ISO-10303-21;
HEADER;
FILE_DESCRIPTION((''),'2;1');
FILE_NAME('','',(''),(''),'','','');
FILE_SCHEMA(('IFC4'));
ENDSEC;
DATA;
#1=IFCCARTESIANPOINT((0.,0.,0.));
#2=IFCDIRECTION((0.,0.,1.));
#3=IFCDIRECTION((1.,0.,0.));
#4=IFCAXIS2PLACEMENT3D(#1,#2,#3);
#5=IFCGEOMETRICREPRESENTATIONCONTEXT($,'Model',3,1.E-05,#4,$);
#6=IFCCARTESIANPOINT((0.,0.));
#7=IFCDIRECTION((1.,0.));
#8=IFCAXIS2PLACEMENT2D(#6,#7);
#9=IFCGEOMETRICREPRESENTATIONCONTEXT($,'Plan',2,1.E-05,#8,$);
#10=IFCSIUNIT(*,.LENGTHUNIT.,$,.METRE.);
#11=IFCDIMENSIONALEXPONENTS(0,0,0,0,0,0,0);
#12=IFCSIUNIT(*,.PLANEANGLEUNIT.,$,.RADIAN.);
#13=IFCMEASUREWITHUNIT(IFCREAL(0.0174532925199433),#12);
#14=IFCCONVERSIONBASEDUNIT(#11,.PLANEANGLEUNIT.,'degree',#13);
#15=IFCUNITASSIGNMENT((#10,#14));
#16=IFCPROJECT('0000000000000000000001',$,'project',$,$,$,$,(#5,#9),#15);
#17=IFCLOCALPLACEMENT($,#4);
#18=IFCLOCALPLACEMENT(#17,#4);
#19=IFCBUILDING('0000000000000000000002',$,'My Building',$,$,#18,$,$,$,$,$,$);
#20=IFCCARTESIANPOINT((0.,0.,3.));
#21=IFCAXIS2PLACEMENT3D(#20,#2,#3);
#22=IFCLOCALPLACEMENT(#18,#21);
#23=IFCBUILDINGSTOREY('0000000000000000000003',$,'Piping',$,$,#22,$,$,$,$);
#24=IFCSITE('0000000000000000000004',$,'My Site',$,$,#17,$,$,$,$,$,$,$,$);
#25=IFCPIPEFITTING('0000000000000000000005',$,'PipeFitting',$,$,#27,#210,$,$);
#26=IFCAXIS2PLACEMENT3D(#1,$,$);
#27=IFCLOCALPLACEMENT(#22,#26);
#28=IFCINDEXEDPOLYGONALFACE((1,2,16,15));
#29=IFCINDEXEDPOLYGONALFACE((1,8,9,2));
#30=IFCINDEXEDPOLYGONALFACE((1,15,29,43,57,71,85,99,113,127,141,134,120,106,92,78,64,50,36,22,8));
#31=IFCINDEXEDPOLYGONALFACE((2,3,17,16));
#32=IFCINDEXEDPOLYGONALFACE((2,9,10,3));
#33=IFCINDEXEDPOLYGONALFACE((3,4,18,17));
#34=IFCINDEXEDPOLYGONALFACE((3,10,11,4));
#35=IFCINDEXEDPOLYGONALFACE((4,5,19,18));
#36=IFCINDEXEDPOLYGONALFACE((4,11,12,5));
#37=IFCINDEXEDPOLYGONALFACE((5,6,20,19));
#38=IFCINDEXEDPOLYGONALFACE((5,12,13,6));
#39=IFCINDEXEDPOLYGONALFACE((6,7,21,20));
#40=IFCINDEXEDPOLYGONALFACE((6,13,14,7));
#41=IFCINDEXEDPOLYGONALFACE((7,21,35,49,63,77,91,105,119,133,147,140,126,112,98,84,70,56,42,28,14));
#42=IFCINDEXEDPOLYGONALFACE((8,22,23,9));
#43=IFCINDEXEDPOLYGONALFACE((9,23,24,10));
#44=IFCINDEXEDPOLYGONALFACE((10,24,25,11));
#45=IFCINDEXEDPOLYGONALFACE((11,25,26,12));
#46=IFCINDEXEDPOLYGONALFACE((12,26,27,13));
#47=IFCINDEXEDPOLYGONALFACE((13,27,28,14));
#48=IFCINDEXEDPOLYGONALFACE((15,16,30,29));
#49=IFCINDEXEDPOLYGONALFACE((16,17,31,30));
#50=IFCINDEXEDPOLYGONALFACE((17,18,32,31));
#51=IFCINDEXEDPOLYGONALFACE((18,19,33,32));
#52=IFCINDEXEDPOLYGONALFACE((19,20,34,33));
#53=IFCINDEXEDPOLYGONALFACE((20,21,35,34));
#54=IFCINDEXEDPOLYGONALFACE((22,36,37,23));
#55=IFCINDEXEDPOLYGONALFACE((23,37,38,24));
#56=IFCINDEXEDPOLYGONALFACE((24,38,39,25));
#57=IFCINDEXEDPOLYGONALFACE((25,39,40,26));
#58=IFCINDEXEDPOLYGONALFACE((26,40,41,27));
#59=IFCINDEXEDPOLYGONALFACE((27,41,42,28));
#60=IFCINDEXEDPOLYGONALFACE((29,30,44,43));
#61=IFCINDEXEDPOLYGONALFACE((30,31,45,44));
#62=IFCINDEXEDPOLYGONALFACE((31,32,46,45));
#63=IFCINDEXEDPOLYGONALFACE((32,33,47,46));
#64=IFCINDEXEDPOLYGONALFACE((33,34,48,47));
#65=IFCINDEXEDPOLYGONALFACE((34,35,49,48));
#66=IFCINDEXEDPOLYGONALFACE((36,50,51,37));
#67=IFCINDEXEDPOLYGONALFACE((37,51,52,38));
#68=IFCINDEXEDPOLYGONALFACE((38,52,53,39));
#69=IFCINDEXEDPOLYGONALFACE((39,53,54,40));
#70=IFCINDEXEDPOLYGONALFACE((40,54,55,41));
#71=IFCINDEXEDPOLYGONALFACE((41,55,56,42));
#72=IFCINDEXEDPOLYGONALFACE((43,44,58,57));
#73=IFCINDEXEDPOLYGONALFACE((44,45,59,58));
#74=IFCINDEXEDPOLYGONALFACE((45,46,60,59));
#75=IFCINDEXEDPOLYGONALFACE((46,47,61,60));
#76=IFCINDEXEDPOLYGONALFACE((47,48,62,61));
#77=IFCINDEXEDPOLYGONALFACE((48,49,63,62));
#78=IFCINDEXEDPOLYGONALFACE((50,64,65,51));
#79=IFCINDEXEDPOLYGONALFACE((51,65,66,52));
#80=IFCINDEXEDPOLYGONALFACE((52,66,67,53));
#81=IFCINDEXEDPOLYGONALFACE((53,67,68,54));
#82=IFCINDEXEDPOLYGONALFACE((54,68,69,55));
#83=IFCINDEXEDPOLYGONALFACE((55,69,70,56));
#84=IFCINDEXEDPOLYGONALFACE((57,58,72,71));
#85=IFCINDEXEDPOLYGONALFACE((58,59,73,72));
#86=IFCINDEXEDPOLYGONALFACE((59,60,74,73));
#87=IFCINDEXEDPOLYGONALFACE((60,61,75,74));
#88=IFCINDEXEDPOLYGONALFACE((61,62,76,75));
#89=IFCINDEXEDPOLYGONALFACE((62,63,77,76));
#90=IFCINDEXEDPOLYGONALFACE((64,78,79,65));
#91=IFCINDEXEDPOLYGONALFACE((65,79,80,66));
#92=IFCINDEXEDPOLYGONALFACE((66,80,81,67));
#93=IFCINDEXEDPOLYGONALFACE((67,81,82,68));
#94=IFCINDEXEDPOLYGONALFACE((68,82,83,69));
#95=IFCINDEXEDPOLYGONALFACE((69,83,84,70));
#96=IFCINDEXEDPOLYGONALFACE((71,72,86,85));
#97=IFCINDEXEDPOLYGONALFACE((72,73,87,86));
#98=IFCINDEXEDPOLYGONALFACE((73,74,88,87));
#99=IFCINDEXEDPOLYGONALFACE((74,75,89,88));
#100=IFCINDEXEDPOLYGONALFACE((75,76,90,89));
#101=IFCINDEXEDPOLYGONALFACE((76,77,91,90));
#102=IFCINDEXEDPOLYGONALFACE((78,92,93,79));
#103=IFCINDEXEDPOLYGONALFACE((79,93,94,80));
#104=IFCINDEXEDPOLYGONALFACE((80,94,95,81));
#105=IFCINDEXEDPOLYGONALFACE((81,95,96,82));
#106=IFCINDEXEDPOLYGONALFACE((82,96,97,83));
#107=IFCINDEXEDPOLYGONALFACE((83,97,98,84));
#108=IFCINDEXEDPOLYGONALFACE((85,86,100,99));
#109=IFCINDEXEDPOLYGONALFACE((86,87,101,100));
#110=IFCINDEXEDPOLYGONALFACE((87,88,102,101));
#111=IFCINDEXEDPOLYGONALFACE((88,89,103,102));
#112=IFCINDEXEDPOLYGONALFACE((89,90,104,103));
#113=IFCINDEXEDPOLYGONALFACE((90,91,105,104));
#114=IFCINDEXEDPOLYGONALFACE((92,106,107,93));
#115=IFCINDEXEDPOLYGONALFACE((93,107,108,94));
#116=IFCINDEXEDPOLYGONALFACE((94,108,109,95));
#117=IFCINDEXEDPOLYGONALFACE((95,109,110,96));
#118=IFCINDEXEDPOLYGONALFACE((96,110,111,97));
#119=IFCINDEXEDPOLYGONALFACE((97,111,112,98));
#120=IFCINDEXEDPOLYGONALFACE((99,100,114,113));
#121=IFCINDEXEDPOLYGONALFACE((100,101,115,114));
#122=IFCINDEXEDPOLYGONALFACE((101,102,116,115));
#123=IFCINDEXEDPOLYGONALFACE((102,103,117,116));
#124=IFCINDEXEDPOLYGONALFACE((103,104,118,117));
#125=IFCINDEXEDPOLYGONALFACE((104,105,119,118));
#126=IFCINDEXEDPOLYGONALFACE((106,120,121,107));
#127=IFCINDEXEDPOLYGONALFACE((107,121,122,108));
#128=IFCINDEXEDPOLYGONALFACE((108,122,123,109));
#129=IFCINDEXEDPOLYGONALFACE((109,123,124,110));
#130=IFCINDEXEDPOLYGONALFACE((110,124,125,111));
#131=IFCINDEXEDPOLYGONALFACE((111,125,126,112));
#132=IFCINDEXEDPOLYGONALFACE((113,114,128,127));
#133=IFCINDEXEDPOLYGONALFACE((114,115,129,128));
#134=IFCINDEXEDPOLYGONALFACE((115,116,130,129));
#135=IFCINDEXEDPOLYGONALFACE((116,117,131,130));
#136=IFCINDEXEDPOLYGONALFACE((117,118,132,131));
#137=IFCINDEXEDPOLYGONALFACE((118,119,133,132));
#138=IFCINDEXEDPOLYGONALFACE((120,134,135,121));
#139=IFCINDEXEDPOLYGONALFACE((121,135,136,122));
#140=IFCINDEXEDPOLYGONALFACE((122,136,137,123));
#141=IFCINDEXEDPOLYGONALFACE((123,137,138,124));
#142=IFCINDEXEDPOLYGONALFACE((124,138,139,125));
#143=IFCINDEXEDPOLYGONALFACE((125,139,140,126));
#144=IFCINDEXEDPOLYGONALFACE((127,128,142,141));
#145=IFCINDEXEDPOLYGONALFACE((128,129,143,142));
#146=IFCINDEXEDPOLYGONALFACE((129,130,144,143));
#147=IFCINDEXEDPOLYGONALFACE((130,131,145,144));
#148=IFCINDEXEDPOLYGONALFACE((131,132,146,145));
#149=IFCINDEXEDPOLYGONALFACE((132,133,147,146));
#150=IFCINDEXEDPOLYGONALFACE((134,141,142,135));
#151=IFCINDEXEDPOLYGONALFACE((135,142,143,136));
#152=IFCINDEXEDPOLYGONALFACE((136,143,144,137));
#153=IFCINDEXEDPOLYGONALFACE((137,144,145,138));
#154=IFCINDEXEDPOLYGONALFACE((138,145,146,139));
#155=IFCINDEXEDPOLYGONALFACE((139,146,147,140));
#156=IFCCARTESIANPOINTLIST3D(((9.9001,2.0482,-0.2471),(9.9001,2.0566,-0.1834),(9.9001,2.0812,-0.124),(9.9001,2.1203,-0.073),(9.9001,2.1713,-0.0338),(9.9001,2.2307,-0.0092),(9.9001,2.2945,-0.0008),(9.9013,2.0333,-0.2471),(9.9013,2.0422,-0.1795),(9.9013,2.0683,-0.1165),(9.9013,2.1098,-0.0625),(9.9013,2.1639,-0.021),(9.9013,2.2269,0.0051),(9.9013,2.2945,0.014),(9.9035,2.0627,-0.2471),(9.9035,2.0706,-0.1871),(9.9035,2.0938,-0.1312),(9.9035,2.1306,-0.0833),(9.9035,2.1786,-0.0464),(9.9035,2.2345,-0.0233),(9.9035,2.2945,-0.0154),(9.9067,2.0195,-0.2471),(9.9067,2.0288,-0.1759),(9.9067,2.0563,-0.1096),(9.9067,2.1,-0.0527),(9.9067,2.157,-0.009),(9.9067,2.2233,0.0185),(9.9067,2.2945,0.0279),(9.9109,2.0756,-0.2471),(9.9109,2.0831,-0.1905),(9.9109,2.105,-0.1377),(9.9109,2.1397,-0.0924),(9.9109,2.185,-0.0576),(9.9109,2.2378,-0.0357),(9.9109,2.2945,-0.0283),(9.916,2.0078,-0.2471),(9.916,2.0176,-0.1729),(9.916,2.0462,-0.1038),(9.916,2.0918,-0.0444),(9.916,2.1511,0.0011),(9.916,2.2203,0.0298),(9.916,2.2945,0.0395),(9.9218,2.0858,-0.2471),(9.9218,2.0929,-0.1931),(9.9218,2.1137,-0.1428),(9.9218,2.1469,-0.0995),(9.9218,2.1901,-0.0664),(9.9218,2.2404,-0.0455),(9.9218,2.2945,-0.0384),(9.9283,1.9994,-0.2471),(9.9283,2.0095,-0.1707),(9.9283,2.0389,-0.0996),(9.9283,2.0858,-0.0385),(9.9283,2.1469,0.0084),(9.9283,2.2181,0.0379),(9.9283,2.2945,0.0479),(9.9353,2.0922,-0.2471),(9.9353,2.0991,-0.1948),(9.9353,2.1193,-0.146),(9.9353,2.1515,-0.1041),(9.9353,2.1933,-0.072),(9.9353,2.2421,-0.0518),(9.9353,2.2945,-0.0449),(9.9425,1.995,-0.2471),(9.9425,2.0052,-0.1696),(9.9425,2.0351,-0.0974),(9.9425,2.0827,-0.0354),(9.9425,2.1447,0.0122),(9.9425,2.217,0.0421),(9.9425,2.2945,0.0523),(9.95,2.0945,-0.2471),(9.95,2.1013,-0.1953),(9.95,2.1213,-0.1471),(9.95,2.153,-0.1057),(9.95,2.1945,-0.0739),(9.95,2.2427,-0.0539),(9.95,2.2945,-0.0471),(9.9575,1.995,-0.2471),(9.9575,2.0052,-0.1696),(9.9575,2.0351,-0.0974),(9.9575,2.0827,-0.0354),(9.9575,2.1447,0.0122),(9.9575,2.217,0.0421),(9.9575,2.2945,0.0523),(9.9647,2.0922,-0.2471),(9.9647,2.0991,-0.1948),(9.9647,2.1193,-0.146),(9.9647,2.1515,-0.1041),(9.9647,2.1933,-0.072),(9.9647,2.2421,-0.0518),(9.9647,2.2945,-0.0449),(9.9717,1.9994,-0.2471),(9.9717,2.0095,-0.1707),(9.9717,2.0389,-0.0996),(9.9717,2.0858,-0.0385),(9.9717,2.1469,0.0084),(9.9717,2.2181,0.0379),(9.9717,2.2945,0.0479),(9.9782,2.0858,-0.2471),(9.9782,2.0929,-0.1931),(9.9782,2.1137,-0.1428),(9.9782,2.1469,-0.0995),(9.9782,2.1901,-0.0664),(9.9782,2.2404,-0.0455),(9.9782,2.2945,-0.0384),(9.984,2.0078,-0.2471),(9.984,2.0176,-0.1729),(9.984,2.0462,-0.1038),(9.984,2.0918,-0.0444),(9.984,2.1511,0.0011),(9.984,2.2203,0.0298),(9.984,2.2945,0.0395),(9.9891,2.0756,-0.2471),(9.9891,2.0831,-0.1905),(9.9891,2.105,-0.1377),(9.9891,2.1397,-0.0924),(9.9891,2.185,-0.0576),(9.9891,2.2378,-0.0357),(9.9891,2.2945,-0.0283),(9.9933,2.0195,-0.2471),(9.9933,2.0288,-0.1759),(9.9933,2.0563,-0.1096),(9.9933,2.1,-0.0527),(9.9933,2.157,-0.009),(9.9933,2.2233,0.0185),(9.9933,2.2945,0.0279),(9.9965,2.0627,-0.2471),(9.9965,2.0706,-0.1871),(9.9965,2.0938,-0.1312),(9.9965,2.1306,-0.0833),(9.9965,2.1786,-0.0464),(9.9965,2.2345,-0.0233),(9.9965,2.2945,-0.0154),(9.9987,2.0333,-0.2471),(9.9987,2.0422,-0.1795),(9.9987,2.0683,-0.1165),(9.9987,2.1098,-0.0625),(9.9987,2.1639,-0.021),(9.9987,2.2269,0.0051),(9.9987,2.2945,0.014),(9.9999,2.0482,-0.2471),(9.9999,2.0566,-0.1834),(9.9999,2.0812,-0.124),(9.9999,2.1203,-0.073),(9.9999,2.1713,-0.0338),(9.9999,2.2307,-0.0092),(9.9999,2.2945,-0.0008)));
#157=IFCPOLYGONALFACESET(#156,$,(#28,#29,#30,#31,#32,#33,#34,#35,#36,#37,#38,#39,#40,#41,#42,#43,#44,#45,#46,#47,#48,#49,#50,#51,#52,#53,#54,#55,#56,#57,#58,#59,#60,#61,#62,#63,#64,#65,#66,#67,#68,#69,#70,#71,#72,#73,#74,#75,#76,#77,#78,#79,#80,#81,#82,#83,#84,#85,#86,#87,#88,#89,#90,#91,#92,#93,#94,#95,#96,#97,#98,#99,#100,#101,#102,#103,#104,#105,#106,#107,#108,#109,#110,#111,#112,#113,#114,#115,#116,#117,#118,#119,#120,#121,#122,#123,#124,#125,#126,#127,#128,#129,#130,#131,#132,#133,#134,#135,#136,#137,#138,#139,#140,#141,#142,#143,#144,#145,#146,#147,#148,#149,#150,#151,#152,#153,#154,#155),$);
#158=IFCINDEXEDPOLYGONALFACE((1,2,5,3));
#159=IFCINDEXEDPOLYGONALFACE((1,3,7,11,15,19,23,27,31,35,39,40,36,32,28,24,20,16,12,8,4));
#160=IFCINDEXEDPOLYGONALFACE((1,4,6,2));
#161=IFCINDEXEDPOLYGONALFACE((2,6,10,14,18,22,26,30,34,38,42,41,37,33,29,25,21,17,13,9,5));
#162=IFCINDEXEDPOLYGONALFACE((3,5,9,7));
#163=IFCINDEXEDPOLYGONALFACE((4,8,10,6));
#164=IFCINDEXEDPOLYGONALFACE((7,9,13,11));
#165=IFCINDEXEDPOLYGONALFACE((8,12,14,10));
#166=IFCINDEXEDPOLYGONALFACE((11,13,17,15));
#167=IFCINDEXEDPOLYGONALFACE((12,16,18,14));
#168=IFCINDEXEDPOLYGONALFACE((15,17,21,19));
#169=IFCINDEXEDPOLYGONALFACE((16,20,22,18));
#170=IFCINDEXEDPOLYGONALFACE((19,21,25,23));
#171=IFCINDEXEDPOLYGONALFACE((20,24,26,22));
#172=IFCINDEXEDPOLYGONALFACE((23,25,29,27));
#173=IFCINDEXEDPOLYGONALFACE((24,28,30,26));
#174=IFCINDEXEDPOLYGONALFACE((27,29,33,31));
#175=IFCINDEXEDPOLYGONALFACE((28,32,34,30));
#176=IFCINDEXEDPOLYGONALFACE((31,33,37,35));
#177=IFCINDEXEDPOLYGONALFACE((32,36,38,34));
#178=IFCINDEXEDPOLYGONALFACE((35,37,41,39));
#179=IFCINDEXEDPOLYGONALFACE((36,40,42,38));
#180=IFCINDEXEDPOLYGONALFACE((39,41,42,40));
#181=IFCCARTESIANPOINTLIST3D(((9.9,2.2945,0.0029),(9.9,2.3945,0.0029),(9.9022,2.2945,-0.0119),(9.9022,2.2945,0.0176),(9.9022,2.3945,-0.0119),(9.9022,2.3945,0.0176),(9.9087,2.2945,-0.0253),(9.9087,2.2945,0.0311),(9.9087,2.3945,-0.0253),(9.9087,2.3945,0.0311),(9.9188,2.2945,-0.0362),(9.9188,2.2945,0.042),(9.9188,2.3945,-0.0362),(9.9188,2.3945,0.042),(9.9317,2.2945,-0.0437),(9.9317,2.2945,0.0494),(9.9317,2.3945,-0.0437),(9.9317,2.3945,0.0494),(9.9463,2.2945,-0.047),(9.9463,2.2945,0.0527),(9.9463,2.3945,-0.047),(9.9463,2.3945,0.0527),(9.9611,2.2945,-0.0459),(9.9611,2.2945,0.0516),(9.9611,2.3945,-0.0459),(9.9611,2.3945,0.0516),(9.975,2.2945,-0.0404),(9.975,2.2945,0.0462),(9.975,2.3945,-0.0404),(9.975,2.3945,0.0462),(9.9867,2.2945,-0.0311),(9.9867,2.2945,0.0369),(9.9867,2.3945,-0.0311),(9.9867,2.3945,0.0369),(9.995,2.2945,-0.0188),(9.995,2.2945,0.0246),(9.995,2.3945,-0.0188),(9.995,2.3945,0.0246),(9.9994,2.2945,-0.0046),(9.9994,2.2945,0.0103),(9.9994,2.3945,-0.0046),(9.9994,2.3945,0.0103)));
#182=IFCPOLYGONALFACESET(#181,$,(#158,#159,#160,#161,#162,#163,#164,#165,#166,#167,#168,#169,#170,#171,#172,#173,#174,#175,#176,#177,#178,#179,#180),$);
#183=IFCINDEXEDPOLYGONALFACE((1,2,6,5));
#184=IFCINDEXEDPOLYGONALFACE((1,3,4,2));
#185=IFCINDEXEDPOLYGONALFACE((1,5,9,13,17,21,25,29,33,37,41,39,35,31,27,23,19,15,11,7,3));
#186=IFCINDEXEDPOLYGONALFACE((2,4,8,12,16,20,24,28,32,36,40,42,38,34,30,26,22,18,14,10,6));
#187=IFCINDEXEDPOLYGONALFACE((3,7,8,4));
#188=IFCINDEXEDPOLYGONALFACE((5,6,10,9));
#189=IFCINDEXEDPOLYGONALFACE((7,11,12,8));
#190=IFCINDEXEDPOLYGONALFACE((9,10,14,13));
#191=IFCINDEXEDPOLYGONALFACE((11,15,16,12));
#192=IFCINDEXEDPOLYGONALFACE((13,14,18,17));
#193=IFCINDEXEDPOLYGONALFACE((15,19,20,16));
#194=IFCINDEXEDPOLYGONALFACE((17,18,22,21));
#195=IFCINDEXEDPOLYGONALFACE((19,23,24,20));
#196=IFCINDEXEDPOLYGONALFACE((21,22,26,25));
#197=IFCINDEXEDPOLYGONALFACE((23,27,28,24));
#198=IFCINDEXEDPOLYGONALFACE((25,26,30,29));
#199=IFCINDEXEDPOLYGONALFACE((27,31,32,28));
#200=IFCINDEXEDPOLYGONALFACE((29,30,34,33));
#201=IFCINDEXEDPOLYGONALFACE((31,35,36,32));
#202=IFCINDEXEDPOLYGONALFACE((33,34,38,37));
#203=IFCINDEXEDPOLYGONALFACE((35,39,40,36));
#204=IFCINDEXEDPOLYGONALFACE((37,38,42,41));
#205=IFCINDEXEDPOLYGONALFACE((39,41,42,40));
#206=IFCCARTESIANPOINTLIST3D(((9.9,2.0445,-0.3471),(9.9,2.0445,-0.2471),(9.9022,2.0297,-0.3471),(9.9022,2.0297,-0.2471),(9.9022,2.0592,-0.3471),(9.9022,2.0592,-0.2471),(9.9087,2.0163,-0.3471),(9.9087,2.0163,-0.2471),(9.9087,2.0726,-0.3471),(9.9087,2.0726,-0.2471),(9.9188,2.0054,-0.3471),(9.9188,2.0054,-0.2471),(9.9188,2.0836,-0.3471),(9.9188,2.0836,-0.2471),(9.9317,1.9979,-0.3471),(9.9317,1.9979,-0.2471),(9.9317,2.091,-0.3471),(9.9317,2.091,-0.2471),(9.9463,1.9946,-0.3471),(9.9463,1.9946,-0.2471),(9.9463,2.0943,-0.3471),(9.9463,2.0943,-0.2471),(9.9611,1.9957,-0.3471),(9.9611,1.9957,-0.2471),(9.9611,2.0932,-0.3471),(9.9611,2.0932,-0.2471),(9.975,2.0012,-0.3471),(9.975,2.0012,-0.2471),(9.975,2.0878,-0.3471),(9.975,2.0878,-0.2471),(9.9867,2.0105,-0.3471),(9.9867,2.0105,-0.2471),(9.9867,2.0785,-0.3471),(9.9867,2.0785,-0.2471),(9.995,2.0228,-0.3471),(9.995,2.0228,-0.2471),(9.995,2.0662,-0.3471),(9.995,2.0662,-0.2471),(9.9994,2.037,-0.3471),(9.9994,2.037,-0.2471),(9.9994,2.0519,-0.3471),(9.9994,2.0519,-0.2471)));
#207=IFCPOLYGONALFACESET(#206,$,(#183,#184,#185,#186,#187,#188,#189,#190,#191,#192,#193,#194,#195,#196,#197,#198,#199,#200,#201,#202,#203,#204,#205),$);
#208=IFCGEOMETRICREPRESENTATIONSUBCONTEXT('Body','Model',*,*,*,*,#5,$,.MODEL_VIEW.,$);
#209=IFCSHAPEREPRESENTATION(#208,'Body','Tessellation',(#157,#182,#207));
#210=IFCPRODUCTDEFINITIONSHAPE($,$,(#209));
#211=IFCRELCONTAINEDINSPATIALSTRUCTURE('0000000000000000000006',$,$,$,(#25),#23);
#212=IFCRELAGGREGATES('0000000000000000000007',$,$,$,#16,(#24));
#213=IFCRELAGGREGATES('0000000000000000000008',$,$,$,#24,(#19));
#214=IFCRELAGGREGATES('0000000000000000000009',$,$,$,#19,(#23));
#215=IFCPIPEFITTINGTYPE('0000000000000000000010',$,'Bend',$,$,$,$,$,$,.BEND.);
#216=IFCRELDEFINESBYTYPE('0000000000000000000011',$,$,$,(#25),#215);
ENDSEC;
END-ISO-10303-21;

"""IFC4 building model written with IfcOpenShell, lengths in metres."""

from ifc_helpers import new_model, entity, si_unit, converted_unit, frame, origin_with_axes, origin_2d_with_axis, place, context, subcontext, project, spatial, circle, extrude, source, transform, mapped, type_object, type_shapes, element, save


model = new_model("IFC4")

# Units and contexts
model_context = context("Model", 3, precision=1e-05, world=origin_with_axes())
plan_context = context("Plan", 2, precision=1e-05, world=origin_2d_with_axis())
body_context = subcontext(model_context, "Body", "Model", "MODEL_VIEW")
ifc_project = project(units=[si_unit("LENGTHUNIT", "METRE"), converted_unit("PLANEANGLEUNIT", "degree", entity("IfcReal", 0.0174532925199433), si_unit("PLANEANGLEUNIT", "RADIAN"), dimensions=[0, 0, 0, 0, 0, 0, 0])], contexts=[model_context, plan_context])

# Site, building, storey
site_placement = place(None, origin_with_axes())
site = spatial("IfcSite", under=ifc_project, at=site_placement, Name="My Site")
building_placement = place(site_placement, origin_with_axes())
building = spatial("IfcBuilding", under=site, at=building_placement, Name="My Building")
storey_placement = place(building_placement, frame((0.0, 0.0, 3.0), z_axis=(0.0, 0.0, 1.0), x_axis=(1.0, 0.0, 0.0)))
storey = spatial("IfcBuildingStorey", under=building, at=storey_placement, Name="Piping")

# Pipe fitting
pipe_fitting_type_1 = type_object("IfcPipeFittingType", Name="Bend", PredefinedType="BEND")
shared_shape = source(origin_with_axes(), body_context, "Body", "SolidModel", [
    entity("IfcSweptDiskSolid", entity("IfcIndexedPolyCurve", entity("IfcCartesianPointList3D", [[0.0, 0.0, -0.1], [0.0, -0.0732, -0.2768], [0.0, -0.25, -0.35]]), [entity("IfcArcIndex", [1, 2, 3])]), 0.05),
    extrude(circle(Radius=0.05), origin_with_axes(), (0.0, 0.0, -1.0), 0.1),
    extrude(circle(Radius=0.05), frame((0.0, -0.25, -0.35), z_axis=(0.0, -1.0, 0.0), x_axis=(1.0, 0.0, 0.0)), (0.0, 0.0, 1.0), 0.1),
])
type_shapes(pipe_fitting_type_1, [shared_shape])
for number, where, z_axis, x_axis, name in (
    (1, (9.95, 2.3945, 0.0029), (0.0, 1.0, 0.0), (-1.0, 0.0, 0.0), "PipeFitting"),
):
    element("IfcPipeFitting", number, at=place(storey_placement, frame(where, z_axis=z_axis, x_axis=x_axis)), inside=storey, type_object=pipe_fitting_type_1, Name=name, context=body_context, shape_type="MappedRepresentation", body=[
        mapped(shared_shape, transform((0.0, 0.0, 0.0), x_axis=(1.0, 0.0, 0.0), y_axis=(0.0, 1.0, 0.0), z_axis=(0.0, 0.0, 1.0), scale=1.0)),
    ])

save(model, "model.ifc")
